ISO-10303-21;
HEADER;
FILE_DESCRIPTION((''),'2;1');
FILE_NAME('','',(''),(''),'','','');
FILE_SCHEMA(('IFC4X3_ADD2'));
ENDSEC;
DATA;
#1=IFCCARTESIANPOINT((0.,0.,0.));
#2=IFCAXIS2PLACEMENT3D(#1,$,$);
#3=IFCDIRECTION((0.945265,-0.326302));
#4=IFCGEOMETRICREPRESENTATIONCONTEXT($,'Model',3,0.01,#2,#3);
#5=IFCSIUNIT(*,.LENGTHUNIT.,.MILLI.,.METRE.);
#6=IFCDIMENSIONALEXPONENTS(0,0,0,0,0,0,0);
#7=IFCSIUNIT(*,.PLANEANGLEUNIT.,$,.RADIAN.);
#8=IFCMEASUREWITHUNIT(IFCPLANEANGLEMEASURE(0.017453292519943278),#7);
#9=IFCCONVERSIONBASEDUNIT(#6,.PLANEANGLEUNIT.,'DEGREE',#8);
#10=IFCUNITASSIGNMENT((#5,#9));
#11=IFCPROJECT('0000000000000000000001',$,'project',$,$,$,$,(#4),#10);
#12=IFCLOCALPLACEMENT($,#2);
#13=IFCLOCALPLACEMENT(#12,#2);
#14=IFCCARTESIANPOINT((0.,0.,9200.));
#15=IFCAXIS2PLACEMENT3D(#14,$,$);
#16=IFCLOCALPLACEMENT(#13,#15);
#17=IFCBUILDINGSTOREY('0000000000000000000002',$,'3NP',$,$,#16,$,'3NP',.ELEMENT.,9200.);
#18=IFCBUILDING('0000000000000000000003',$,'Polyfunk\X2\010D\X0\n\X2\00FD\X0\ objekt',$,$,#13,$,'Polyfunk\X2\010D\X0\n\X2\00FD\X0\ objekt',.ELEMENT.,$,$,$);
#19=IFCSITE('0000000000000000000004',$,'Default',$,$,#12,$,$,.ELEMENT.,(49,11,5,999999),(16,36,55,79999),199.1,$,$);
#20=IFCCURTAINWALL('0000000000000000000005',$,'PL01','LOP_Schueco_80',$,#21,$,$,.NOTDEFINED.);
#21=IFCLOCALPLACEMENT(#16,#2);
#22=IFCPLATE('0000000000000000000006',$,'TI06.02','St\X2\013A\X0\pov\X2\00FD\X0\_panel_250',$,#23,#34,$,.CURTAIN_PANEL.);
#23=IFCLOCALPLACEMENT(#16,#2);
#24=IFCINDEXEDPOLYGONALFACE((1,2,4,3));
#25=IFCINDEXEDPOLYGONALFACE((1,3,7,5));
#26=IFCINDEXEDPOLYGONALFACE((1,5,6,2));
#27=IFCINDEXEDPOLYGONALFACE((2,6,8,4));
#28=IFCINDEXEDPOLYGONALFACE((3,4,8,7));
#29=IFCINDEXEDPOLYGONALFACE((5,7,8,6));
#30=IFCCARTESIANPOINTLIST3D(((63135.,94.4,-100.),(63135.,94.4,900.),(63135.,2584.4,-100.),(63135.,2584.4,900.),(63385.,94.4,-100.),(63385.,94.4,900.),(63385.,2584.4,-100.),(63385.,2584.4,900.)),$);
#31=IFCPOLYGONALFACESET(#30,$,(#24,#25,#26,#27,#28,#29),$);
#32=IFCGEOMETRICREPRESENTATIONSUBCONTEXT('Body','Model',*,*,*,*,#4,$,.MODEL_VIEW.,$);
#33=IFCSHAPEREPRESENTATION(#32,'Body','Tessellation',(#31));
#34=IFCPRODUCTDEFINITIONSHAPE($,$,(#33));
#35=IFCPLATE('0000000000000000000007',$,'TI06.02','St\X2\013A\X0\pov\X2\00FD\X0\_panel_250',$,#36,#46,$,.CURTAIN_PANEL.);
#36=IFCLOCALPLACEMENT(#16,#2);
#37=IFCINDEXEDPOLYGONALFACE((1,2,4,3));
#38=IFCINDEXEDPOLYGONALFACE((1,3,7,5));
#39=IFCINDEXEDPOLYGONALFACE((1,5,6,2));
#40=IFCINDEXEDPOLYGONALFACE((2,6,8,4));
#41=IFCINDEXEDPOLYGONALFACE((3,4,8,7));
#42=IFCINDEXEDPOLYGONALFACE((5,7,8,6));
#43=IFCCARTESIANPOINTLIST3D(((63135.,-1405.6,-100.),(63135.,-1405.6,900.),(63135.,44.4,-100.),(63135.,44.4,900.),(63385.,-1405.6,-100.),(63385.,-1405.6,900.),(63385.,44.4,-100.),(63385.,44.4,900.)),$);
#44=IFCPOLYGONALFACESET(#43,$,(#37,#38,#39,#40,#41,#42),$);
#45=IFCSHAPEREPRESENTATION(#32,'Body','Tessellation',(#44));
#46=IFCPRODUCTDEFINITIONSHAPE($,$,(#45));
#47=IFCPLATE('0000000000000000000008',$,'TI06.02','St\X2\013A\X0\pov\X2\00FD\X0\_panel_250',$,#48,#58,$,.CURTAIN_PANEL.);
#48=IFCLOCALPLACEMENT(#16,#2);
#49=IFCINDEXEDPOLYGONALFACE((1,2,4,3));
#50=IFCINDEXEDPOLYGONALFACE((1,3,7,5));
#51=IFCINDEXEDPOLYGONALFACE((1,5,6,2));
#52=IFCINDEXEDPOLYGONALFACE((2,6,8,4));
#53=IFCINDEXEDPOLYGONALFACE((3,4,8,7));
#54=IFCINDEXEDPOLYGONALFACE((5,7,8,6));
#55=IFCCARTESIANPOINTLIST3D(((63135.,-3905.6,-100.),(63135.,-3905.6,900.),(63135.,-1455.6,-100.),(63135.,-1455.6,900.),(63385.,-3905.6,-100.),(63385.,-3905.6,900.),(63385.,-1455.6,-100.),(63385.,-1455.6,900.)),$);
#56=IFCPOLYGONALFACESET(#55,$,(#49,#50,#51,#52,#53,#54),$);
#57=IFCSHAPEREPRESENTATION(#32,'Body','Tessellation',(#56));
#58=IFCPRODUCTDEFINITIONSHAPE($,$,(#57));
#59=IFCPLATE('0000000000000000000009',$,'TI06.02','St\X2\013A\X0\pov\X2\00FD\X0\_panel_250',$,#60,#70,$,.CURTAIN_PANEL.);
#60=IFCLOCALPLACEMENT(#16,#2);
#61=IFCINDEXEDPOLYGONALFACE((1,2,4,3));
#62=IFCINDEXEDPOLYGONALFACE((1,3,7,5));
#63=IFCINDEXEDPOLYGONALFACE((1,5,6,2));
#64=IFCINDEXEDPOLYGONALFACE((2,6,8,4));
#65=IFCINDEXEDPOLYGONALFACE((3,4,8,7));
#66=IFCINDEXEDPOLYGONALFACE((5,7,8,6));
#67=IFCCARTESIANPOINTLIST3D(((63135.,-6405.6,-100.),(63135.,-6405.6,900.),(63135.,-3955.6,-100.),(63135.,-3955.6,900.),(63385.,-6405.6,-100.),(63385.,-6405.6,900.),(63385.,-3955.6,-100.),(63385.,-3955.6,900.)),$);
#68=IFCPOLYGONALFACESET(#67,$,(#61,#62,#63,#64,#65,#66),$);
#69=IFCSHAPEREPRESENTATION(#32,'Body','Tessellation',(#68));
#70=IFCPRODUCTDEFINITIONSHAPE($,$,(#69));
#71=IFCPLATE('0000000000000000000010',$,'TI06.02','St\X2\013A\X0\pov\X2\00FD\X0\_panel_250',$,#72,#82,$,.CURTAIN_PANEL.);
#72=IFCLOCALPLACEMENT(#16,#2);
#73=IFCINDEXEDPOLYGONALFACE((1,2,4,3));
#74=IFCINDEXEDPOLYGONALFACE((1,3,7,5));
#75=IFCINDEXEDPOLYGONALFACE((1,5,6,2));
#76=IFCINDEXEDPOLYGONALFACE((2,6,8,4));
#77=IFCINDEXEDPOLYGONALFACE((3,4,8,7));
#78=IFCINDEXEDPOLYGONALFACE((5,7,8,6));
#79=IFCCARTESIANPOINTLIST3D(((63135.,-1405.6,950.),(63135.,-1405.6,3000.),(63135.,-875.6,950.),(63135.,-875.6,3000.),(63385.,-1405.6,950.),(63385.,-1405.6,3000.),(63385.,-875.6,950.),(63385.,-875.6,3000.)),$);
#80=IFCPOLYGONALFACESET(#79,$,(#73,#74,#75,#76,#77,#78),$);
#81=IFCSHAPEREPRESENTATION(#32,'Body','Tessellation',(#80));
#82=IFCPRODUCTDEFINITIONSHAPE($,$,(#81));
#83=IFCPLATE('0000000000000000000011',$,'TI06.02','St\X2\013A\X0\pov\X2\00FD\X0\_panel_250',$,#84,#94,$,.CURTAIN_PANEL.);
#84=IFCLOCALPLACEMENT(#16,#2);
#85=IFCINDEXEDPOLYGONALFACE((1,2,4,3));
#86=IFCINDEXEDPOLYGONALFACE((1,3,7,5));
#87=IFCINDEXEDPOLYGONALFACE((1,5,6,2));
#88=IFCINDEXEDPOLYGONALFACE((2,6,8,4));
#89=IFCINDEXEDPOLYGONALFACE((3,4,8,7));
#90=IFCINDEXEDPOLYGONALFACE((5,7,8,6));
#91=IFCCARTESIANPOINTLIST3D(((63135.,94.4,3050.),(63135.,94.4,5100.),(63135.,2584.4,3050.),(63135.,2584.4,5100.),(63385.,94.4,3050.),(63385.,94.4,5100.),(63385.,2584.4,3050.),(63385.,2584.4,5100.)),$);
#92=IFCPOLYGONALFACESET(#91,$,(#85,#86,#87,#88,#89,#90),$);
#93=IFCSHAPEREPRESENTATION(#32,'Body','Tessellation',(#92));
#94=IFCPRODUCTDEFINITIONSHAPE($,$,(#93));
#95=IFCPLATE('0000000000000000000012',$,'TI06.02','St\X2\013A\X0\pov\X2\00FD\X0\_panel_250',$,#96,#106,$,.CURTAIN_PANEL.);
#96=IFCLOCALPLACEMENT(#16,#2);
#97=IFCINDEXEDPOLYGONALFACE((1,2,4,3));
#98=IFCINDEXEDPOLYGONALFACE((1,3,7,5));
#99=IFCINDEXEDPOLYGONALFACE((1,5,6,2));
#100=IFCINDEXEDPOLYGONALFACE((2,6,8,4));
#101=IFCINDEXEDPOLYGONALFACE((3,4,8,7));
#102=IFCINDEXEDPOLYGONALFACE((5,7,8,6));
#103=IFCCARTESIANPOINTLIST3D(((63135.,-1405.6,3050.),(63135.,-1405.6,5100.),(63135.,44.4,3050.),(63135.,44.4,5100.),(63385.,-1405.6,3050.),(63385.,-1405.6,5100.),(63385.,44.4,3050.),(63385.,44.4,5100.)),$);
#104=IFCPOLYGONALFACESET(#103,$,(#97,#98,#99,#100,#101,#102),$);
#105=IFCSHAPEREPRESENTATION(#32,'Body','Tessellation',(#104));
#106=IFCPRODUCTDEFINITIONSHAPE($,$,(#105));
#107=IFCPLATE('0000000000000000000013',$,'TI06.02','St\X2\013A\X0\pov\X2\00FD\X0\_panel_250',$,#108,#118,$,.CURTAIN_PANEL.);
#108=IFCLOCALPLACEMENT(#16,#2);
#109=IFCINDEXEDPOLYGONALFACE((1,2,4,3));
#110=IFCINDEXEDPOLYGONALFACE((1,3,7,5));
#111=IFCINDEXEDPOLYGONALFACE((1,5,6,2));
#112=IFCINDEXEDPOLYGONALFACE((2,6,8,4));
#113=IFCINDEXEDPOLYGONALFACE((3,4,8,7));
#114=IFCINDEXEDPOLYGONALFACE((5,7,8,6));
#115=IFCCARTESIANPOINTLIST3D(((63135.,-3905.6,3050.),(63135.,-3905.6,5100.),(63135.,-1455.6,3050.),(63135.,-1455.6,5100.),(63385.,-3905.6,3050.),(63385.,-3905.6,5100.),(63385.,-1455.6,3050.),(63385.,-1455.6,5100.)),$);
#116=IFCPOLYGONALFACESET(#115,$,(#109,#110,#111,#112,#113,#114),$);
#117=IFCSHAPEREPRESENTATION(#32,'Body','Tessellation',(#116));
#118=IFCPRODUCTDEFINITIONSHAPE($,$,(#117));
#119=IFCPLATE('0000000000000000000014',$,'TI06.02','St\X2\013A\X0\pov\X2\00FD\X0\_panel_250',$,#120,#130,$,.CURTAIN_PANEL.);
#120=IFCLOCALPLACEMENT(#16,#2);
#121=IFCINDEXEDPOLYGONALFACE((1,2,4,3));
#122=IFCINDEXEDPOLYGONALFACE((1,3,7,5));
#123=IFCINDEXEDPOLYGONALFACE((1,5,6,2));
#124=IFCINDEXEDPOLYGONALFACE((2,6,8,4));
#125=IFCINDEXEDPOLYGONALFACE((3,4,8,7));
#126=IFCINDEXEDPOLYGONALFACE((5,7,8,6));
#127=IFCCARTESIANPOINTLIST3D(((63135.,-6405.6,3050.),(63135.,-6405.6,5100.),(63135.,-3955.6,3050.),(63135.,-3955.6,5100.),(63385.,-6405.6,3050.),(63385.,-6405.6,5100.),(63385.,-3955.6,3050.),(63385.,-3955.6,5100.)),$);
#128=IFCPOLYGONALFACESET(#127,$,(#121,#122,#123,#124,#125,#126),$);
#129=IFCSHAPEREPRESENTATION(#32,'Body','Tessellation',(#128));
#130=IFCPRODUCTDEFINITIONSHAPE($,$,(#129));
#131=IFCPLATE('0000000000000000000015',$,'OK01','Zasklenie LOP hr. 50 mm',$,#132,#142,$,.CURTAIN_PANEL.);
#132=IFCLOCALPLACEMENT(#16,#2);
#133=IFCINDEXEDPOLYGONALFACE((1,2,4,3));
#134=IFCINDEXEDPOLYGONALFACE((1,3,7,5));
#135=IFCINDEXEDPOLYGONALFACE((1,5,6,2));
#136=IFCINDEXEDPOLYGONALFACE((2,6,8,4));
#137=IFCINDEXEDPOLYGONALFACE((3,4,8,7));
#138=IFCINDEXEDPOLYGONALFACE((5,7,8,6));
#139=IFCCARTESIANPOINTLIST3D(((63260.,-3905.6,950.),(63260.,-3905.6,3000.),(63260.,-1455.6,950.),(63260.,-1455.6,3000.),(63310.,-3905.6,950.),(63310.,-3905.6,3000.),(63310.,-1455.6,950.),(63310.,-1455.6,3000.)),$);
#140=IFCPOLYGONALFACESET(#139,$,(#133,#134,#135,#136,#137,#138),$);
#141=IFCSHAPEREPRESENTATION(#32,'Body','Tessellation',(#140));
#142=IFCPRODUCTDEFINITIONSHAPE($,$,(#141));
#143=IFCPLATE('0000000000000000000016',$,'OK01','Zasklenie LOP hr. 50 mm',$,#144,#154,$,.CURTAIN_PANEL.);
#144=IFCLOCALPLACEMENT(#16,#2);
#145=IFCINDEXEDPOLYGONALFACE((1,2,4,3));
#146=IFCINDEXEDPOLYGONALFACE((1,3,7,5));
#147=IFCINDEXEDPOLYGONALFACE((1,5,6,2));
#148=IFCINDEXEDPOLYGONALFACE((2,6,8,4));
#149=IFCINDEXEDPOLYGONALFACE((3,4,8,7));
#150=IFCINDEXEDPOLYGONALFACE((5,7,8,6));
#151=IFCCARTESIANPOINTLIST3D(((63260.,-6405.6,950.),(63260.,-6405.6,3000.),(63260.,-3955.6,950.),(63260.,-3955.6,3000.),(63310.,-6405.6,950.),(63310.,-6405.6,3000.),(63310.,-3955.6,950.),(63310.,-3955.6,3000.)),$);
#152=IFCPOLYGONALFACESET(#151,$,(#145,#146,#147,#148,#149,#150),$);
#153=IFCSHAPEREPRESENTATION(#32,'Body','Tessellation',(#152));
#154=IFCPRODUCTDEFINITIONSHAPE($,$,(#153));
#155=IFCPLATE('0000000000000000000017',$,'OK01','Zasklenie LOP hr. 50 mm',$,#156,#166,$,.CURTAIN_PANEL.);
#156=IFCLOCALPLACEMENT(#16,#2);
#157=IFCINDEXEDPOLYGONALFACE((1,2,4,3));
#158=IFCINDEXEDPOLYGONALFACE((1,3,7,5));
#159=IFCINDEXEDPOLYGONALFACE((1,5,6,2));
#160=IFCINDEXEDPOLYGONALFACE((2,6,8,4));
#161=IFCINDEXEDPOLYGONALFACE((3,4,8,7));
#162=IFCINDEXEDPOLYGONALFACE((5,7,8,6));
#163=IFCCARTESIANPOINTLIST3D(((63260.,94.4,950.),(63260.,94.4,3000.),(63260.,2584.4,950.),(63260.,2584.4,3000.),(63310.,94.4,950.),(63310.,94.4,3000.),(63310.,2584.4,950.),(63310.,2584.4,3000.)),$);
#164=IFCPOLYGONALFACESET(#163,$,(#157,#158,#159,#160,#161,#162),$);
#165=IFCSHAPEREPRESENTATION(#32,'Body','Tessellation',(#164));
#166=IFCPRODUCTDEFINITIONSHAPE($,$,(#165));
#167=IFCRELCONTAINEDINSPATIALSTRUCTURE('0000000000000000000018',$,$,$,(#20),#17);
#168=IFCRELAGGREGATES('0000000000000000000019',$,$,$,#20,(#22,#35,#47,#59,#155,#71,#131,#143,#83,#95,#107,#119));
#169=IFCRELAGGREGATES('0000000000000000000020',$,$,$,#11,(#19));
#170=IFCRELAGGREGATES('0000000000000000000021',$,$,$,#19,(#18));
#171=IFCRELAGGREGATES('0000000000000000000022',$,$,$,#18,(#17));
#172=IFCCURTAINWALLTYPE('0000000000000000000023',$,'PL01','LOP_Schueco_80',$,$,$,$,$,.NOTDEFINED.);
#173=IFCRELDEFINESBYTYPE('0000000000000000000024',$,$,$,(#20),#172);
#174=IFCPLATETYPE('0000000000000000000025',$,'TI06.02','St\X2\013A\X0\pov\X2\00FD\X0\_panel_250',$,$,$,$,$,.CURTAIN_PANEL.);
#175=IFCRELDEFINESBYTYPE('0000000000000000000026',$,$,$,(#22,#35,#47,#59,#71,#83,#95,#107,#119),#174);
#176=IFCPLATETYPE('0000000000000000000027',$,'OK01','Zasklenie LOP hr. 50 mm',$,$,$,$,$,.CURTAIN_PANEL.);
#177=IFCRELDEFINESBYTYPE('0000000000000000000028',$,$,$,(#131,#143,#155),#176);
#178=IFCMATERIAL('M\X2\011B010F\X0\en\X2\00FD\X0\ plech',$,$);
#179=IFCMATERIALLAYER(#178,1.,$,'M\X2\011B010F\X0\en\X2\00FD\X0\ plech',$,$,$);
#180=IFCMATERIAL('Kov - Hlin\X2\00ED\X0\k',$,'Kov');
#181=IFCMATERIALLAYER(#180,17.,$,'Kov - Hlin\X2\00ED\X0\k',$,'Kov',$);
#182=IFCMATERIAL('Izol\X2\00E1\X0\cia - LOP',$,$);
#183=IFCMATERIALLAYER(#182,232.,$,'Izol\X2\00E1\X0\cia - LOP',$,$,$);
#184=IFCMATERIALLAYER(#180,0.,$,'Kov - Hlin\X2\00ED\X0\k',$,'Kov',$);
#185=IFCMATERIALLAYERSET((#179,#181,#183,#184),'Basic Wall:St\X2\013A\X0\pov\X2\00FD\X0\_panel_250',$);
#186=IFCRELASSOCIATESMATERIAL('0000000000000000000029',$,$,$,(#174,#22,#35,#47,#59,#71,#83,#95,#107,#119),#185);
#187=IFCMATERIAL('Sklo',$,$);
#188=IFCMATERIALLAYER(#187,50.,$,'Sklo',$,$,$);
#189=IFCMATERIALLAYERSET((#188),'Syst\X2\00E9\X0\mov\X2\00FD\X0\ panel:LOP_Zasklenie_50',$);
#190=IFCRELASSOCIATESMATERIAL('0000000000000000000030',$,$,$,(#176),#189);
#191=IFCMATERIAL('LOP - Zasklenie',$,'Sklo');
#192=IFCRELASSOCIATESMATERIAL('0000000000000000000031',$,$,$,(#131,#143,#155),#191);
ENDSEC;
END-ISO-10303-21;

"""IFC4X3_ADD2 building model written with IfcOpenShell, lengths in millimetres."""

from ifc_helpers import new_model, entity, si_unit, converted_unit, direction, frame, frame_2d, origin, origin_2d_with_axis, place, context, subcontext, project, spatial, rectangle, extrude, source, transform, mapped, material, layer, layer_set, layer_usage, type_object, type_shapes, element, aggregate, save


model = new_model("IFC4X3_ADD2")

# Units and contexts
model_context = context("Model", 3, precision=0.01, world=origin(), true_north=direction((0.945265, -0.326302)))
body_context = subcontext(model_context, "Body", "Model", "MODEL_VIEW")
ifc_project = project(units=[si_unit("LENGTHUNIT", "METRE", prefix="MILLI"), converted_unit("PLANEANGLEUNIT", "DEGREE", entity("IfcPlaneAngleMeasure", 0.017453292519943278), si_unit("PLANEANGLEUNIT", "RADIAN"), dimensions=[0, 0, 0, 0, 0, 0, 0])], contexts=[model_context])

# Site, building, storey
site_placement = place(None, origin())
site = spatial("IfcSite", under=ifc_project, at=site_placement, Name="Default", CompositionType="ELEMENT", RefLatitude=(49, 11, 5, 999999), RefLongitude=(16, 36, 55, 79999), RefElevation=199.1)
building_placement = place(site_placement, origin())
building = spatial("IfcBuilding", under=site, at=building_placement, Name="Polyfunkčný objekt", LongName="Polyfunkčný objekt", CompositionType="ELEMENT")
storey_placement = place(building_placement, frame((0.0, 0.0, 9200.0)))
storey = spatial("IfcBuildingStorey", under=building, at=storey_placement, Name="3NP", LongName="3NP", CompositionType="ELEMENT", Elevation=9200.0)

# Curtain wall, plates
curtain_wall_type = type_object("IfcCurtainWallType", Name="PL01", Description="LOP_Schueco_80", PredefinedType="NOTDEFINED")
curtain_wall_placement = place(storey_placement, frame((0.0, 0.0, -9200.0)))
curtain_wall = element("IfcCurtainWall", 1, at=curtain_wall_placement, inside=storey, type_object=curtain_wall_type, Name="PL01", Description="LOP_Schueco_80", PredefinedType="NOTDEFINED")
ifc_material_1 = material(Name="Měďený plech")
ifc_layer_1 = layer(ifc_material_1, 1.0, Name="Měďený plech")
ifc_material_2 = material(Name="Kov - Hliník", Category="Kov")
ifc_layer_2 = layer(ifc_material_2, 17.0, Name="Kov - Hliník", Category="Kov")
ifc_material_3 = material(Name="Izolácia - LOP")
ifc_layer_3 = layer(ifc_material_3, 232.0, Name="Izolácia - LOP")
ifc_layer_4 = layer(ifc_material_2, 0.0, Name="Kov - Hliník", Category="Kov")
ifc_layer_set_1 = layer_set([ifc_layer_1, ifc_layer_2, ifc_layer_3, ifc_layer_4], Name="Basic Wall:Stĺpový_panel_250")
ifc_layer_usage_1 = layer_usage(ifc_layer_set_1, "AXIS2", "NEGATIVE", 125.0)
plate_type_1 = type_object("IfcPlateType", Name="TI06.02", Description="Stĺpový_panel_250", PredefinedType="CURTAIN_PANEL", material=ifc_layer_set_1)
plate_1_placement = place(storey_placement, frame((63260.0, 2584.4, -100.0), z_axis=(0.0, 0.0, 1.0), x_axis=(0.0, -1.0, 0.0)))
plate_1 = element("IfcPlate", 2, at=plate_1_placement, type_object=plate_type_1, material=ifc_layer_usage_1, Name="TI06.02", Description="Stĺpový_panel_250", PredefinedType="CURTAIN_PANEL", context=body_context, shape_type="SweptSolid", body=[
    extrude(rectangle(XDim=250.0, YDim=2490.0, at=frame_2d((0.0, 0.0), x_axis=(1.0, 0.0))), frame((1245.0, 0.0, 0.0), z_axis=(0.0, 0.0, 1.0), x_axis=(0.0, 1.0, 0.0)), (0.0, 0.0, 1.0), 1000.0),
])
ifc_layer_usage_2 = layer_usage(ifc_layer_set_1, "AXIS2", "NEGATIVE", 125.0)
plate_2_placement = place(storey_placement, frame((63260.0, 44.4, -100.0), z_axis=(0.0, 0.0, 1.0), x_axis=(0.0, -1.0, 0.0)))
plate_2 = element("IfcPlate", 3, at=plate_2_placement, type_object=plate_type_1, material=ifc_layer_usage_2, Name="TI06.02", Description="Stĺpový_panel_250", PredefinedType="CURTAIN_PANEL", context=body_context, shape_type="SweptSolid", body=[
    extrude(rectangle(XDim=250.0, YDim=1450.0, at=frame_2d((0.0, 0.0), x_axis=(1.0, 0.0))), frame((725.0, 0.0, 0.0), z_axis=(0.0, 0.0, 1.0), x_axis=(0.0, 1.0, 0.0)), (0.0, 0.0, 1.0), 1000.0),
])
ifc_layer_usage_3 = layer_usage(ifc_layer_set_1, "AXIS2", "NEGATIVE", 125.0)
plate_3_placement = place(storey_placement, frame((63260.0, -1455.6, -100.0), z_axis=(0.0, 0.0, 1.0), x_axis=(0.0, -1.0, 0.0)))
plate_3 = element("IfcPlate", 4, at=plate_3_placement, type_object=plate_type_1, material=ifc_layer_usage_3, Name="TI06.02", Description="Stĺpový_panel_250", PredefinedType="CURTAIN_PANEL", context=body_context, shape_type="SweptSolid", body=[
    extrude(rectangle(XDim=250.0, YDim=2450.0, at=frame_2d((0.0, 0.0), x_axis=(1.0, 0.0))), frame((1225.0, 0.0, 0.0), z_axis=(0.0, 0.0, 1.0), x_axis=(0.0, 1.0, 0.0)), (0.0, 0.0, 1.0), 1000.0),
])
ifc_layer_usage_4 = layer_usage(ifc_layer_set_1, "AXIS2", "NEGATIVE", 125.0)
plate_4_placement = place(storey_placement, frame((63260.0, -3955.6, -100.0), z_axis=(0.0, 0.0, 1.0), x_axis=(0.0, -1.0, 0.0)))
plate_4 = element("IfcPlate", 5, at=plate_4_placement, type_object=plate_type_1, material=ifc_layer_usage_4, Name="TI06.02", Description="Stĺpový_panel_250", PredefinedType="CURTAIN_PANEL", context=body_context, shape_type="SweptSolid", body=[
    extrude(rectangle(XDim=250.0, YDim=2450.0, at=frame_2d((0.0, 0.0), x_axis=(1.0, 0.0))), frame((1225.0, 0.0, 0.0), z_axis=(0.0, 0.0, 1.0), x_axis=(0.0, 1.0, 0.0)), (0.0, 0.0, 1.0), 1000.0),
])
ifc_layer_usage_5 = layer_usage(ifc_layer_set_1, "AXIS2", "NEGATIVE", 125.0)
plate_5_placement = place(storey_placement, frame((63260.0, -875.6, 950.0), z_axis=(0.0, 0.0, 1.0), x_axis=(0.0, -1.0, 0.0)))
plate_5 = element("IfcPlate", 6, at=plate_5_placement, type_object=plate_type_1, material=ifc_layer_usage_5, Name="TI06.02", Description="Stĺpový_panel_250", PredefinedType="CURTAIN_PANEL", context=body_context, shape_type="SweptSolid", body=[
    extrude(rectangle(XDim=250.0, YDim=530.0, at=frame_2d((0.0, 0.0), x_axis=(1.0, 0.0))), frame((265.0, 0.0, 0.0), z_axis=(0.0, 0.0, 1.0), x_axis=(0.0, 1.0, 0.0)), (0.0, 0.0, 1.0), 2050.0),
])
ifc_layer_usage_6 = layer_usage(ifc_layer_set_1, "AXIS2", "NEGATIVE", 125.0)
plate_6_placement = place(storey_placement, frame((63260.0, 2584.4, 3050.0), z_axis=(0.0, 0.0, 1.0), x_axis=(0.0, -1.0, 0.0)))
plate_6 = element("IfcPlate", 7, at=plate_6_placement, type_object=plate_type_1, material=ifc_layer_usage_6, Name="TI06.02", Description="Stĺpový_panel_250", PredefinedType="CURTAIN_PANEL", context=body_context, shape_type="SweptSolid", body=[
    extrude(rectangle(XDim=250.0, YDim=2490.0, at=frame_2d((0.0, 0.0), x_axis=(1.0, 0.0))), frame((1245.0, 0.0, 0.0), z_axis=(0.0, 0.0, 1.0), x_axis=(0.0, 1.0, 0.0)), (0.0, 0.0, 1.0), 2050.0),
])
ifc_layer_usage_7 = layer_usage(ifc_layer_set_1, "AXIS2", "NEGATIVE", 125.0)
plate_7_placement = place(storey_placement, frame((63260.0, 44.4, 3050.0), z_axis=(0.0, 0.0, 1.0), x_axis=(0.0, -1.0, 0.0)))
plate_7 = element("IfcPlate", 8, at=plate_7_placement, type_object=plate_type_1, material=ifc_layer_usage_7, Name="TI06.02", Description="Stĺpový_panel_250", PredefinedType="CURTAIN_PANEL", context=body_context, shape_type="SweptSolid", body=[
    extrude(rectangle(XDim=250.0, YDim=1450.0, at=frame_2d((0.0, 0.0), x_axis=(1.0, 0.0))), frame((725.0, 0.0, 0.0), z_axis=(0.0, 0.0, 1.0), x_axis=(0.0, 1.0, 0.0)), (0.0, 0.0, 1.0), 2050.0),
])
ifc_layer_usage_8 = layer_usage(ifc_layer_set_1, "AXIS2", "NEGATIVE", 125.0)
plate_8_placement = place(storey_placement, frame((63260.0, -1455.6, 3050.0), z_axis=(0.0, 0.0, 1.0), x_axis=(0.0, -1.0, 0.0)))
plate_8 = element("IfcPlate", 9, at=plate_8_placement, type_object=plate_type_1, material=ifc_layer_usage_8, Name="TI06.02", Description="Stĺpový_panel_250", PredefinedType="CURTAIN_PANEL", context=body_context, shape_type="SweptSolid", body=[
    extrude(rectangle(XDim=250.0, YDim=2450.0, at=frame_2d((0.0, 0.0), x_axis=(1.0, 0.0))), frame((1225.0, 0.0, 0.0), z_axis=(0.0, 0.0, 1.0), x_axis=(0.0, 1.0, 0.0)), (0.0, 0.0, 1.0), 2050.0),
])
ifc_layer_usage_9 = layer_usage(ifc_layer_set_1, "AXIS2", "NEGATIVE", 125.0)
plate_9_placement = place(storey_placement, frame((63260.0, -3955.6, 3050.0), z_axis=(0.0, 0.0, 1.0), x_axis=(0.0, -1.0, 0.0)))
plate_9 = element("IfcPlate", 10, at=plate_9_placement, type_object=plate_type_1, material=ifc_layer_usage_9, Name="TI06.02", Description="Stĺpový_panel_250", PredefinedType="CURTAIN_PANEL", context=body_context, shape_type="SweptSolid", body=[
    extrude(rectangle(XDim=250.0, YDim=2450.0, at=frame_2d((0.0, 0.0), x_axis=(1.0, 0.0))), frame((1225.0, 0.0, 0.0), z_axis=(0.0, 0.0, 1.0), x_axis=(0.0, 1.0, 0.0)), (0.0, 0.0, 1.0), 2050.0),
])
ifc_material_4 = material(Name="LOP - Zasklenie", Category="Sklo")
ifc_material_5 = material(Name="Sklo")
ifc_layer_5 = layer(ifc_material_5, 50.0, Name="Sklo")
ifc_layer_set_2 = layer_set([ifc_layer_5], Name="Systémový panel:LOP_Zasklenie_50")
plate_type_2 = type_object("IfcPlateType", Name="OK01", Description="Zasklenie LOP hr. 50 mm", PredefinedType="CURTAIN_PANEL", material=ifc_layer_set_2)
shared_shape_1 = source(origin(), body_context, "Body", "SweptSolid", [
    extrude(rectangle(XDim=50.0, YDim=2450.0, at=origin_2d_with_axis()), frame((0.0, 25.0, 0.0), z_axis=(0.0, 0.0, 1.0), x_axis=(0.0, 1.0, 0.0)), (0.0, 0.0, 1.0), 2050.0),
])
plate_10_placement = place(curtain_wall_placement, frame((63260.0, -2680.6, 10150.0), z_axis=(0.0, 0.0, 1.0), x_axis=(0.0, -1.0, 0.0)))
plate_10 = element("IfcPlate", 11, at=plate_10_placement, type_object=plate_type_2, material=ifc_material_4, Name="OK01", Description="Zasklenie LOP hr. 50 mm", PredefinedType="CURTAIN_PANEL", context=body_context, shape_type="MappedRepresentation", body=[
    mapped(shared_shape_1, transform((0.0, 0.0, 0.0), scale=1.0)),
])
plate_11_placement = place(curtain_wall_placement, frame((63260.0, -5180.6, 10150.0), z_axis=(0.0, 0.0, 1.0), x_axis=(0.0, -1.0, 0.0)))
plate_11 = element("IfcPlate", 12, at=plate_11_placement, type_object=plate_type_2, material=ifc_material_4, Name="OK01", Description="Zasklenie LOP hr. 50 mm", PredefinedType="CURTAIN_PANEL", context=body_context, shape_type="MappedRepresentation", body=[
    mapped(shared_shape_1, transform((0.0, 0.0, 0.0), scale=1.0)),
])
shared_shape_2 = source(origin(), body_context, "Body", "SweptSolid", [
    extrude(rectangle(XDim=50.0, YDim=2490.0, at=origin_2d_with_axis()), frame((0.0, 25.0, 0.0), z_axis=(0.0, 0.0, 1.0), x_axis=(0.0, 1.0, 0.0)), (0.0, 0.0, 1.0), 2050.0),
])
type_shapes(plate_type_2, [shared_shape_1, shared_shape_2])
plate_12_placement = place(curtain_wall_placement, frame((63260.0, 1339.4, 10150.0), z_axis=(0.0, 0.0, 1.0), x_axis=(0.0, -1.0, 0.0)))
plate_12 = element("IfcPlate", 13, at=plate_12_placement, type_object=plate_type_2, material=ifc_material_4, Name="OK01", Description="Zasklenie LOP hr. 50 mm", PredefinedType="CURTAIN_PANEL", context=body_context, shape_type="MappedRepresentation", body=[
    mapped(shared_shape_2, transform((0.0, 0.0, 0.0), scale=1.0)),
])
aggregate(curtain_wall, [plate_1, plate_2, plate_3, plate_4, plate_12, plate_5, plate_10, plate_11, plate_6, plate_7, plate_8, plate_9])

save(model, "model.ifc")
